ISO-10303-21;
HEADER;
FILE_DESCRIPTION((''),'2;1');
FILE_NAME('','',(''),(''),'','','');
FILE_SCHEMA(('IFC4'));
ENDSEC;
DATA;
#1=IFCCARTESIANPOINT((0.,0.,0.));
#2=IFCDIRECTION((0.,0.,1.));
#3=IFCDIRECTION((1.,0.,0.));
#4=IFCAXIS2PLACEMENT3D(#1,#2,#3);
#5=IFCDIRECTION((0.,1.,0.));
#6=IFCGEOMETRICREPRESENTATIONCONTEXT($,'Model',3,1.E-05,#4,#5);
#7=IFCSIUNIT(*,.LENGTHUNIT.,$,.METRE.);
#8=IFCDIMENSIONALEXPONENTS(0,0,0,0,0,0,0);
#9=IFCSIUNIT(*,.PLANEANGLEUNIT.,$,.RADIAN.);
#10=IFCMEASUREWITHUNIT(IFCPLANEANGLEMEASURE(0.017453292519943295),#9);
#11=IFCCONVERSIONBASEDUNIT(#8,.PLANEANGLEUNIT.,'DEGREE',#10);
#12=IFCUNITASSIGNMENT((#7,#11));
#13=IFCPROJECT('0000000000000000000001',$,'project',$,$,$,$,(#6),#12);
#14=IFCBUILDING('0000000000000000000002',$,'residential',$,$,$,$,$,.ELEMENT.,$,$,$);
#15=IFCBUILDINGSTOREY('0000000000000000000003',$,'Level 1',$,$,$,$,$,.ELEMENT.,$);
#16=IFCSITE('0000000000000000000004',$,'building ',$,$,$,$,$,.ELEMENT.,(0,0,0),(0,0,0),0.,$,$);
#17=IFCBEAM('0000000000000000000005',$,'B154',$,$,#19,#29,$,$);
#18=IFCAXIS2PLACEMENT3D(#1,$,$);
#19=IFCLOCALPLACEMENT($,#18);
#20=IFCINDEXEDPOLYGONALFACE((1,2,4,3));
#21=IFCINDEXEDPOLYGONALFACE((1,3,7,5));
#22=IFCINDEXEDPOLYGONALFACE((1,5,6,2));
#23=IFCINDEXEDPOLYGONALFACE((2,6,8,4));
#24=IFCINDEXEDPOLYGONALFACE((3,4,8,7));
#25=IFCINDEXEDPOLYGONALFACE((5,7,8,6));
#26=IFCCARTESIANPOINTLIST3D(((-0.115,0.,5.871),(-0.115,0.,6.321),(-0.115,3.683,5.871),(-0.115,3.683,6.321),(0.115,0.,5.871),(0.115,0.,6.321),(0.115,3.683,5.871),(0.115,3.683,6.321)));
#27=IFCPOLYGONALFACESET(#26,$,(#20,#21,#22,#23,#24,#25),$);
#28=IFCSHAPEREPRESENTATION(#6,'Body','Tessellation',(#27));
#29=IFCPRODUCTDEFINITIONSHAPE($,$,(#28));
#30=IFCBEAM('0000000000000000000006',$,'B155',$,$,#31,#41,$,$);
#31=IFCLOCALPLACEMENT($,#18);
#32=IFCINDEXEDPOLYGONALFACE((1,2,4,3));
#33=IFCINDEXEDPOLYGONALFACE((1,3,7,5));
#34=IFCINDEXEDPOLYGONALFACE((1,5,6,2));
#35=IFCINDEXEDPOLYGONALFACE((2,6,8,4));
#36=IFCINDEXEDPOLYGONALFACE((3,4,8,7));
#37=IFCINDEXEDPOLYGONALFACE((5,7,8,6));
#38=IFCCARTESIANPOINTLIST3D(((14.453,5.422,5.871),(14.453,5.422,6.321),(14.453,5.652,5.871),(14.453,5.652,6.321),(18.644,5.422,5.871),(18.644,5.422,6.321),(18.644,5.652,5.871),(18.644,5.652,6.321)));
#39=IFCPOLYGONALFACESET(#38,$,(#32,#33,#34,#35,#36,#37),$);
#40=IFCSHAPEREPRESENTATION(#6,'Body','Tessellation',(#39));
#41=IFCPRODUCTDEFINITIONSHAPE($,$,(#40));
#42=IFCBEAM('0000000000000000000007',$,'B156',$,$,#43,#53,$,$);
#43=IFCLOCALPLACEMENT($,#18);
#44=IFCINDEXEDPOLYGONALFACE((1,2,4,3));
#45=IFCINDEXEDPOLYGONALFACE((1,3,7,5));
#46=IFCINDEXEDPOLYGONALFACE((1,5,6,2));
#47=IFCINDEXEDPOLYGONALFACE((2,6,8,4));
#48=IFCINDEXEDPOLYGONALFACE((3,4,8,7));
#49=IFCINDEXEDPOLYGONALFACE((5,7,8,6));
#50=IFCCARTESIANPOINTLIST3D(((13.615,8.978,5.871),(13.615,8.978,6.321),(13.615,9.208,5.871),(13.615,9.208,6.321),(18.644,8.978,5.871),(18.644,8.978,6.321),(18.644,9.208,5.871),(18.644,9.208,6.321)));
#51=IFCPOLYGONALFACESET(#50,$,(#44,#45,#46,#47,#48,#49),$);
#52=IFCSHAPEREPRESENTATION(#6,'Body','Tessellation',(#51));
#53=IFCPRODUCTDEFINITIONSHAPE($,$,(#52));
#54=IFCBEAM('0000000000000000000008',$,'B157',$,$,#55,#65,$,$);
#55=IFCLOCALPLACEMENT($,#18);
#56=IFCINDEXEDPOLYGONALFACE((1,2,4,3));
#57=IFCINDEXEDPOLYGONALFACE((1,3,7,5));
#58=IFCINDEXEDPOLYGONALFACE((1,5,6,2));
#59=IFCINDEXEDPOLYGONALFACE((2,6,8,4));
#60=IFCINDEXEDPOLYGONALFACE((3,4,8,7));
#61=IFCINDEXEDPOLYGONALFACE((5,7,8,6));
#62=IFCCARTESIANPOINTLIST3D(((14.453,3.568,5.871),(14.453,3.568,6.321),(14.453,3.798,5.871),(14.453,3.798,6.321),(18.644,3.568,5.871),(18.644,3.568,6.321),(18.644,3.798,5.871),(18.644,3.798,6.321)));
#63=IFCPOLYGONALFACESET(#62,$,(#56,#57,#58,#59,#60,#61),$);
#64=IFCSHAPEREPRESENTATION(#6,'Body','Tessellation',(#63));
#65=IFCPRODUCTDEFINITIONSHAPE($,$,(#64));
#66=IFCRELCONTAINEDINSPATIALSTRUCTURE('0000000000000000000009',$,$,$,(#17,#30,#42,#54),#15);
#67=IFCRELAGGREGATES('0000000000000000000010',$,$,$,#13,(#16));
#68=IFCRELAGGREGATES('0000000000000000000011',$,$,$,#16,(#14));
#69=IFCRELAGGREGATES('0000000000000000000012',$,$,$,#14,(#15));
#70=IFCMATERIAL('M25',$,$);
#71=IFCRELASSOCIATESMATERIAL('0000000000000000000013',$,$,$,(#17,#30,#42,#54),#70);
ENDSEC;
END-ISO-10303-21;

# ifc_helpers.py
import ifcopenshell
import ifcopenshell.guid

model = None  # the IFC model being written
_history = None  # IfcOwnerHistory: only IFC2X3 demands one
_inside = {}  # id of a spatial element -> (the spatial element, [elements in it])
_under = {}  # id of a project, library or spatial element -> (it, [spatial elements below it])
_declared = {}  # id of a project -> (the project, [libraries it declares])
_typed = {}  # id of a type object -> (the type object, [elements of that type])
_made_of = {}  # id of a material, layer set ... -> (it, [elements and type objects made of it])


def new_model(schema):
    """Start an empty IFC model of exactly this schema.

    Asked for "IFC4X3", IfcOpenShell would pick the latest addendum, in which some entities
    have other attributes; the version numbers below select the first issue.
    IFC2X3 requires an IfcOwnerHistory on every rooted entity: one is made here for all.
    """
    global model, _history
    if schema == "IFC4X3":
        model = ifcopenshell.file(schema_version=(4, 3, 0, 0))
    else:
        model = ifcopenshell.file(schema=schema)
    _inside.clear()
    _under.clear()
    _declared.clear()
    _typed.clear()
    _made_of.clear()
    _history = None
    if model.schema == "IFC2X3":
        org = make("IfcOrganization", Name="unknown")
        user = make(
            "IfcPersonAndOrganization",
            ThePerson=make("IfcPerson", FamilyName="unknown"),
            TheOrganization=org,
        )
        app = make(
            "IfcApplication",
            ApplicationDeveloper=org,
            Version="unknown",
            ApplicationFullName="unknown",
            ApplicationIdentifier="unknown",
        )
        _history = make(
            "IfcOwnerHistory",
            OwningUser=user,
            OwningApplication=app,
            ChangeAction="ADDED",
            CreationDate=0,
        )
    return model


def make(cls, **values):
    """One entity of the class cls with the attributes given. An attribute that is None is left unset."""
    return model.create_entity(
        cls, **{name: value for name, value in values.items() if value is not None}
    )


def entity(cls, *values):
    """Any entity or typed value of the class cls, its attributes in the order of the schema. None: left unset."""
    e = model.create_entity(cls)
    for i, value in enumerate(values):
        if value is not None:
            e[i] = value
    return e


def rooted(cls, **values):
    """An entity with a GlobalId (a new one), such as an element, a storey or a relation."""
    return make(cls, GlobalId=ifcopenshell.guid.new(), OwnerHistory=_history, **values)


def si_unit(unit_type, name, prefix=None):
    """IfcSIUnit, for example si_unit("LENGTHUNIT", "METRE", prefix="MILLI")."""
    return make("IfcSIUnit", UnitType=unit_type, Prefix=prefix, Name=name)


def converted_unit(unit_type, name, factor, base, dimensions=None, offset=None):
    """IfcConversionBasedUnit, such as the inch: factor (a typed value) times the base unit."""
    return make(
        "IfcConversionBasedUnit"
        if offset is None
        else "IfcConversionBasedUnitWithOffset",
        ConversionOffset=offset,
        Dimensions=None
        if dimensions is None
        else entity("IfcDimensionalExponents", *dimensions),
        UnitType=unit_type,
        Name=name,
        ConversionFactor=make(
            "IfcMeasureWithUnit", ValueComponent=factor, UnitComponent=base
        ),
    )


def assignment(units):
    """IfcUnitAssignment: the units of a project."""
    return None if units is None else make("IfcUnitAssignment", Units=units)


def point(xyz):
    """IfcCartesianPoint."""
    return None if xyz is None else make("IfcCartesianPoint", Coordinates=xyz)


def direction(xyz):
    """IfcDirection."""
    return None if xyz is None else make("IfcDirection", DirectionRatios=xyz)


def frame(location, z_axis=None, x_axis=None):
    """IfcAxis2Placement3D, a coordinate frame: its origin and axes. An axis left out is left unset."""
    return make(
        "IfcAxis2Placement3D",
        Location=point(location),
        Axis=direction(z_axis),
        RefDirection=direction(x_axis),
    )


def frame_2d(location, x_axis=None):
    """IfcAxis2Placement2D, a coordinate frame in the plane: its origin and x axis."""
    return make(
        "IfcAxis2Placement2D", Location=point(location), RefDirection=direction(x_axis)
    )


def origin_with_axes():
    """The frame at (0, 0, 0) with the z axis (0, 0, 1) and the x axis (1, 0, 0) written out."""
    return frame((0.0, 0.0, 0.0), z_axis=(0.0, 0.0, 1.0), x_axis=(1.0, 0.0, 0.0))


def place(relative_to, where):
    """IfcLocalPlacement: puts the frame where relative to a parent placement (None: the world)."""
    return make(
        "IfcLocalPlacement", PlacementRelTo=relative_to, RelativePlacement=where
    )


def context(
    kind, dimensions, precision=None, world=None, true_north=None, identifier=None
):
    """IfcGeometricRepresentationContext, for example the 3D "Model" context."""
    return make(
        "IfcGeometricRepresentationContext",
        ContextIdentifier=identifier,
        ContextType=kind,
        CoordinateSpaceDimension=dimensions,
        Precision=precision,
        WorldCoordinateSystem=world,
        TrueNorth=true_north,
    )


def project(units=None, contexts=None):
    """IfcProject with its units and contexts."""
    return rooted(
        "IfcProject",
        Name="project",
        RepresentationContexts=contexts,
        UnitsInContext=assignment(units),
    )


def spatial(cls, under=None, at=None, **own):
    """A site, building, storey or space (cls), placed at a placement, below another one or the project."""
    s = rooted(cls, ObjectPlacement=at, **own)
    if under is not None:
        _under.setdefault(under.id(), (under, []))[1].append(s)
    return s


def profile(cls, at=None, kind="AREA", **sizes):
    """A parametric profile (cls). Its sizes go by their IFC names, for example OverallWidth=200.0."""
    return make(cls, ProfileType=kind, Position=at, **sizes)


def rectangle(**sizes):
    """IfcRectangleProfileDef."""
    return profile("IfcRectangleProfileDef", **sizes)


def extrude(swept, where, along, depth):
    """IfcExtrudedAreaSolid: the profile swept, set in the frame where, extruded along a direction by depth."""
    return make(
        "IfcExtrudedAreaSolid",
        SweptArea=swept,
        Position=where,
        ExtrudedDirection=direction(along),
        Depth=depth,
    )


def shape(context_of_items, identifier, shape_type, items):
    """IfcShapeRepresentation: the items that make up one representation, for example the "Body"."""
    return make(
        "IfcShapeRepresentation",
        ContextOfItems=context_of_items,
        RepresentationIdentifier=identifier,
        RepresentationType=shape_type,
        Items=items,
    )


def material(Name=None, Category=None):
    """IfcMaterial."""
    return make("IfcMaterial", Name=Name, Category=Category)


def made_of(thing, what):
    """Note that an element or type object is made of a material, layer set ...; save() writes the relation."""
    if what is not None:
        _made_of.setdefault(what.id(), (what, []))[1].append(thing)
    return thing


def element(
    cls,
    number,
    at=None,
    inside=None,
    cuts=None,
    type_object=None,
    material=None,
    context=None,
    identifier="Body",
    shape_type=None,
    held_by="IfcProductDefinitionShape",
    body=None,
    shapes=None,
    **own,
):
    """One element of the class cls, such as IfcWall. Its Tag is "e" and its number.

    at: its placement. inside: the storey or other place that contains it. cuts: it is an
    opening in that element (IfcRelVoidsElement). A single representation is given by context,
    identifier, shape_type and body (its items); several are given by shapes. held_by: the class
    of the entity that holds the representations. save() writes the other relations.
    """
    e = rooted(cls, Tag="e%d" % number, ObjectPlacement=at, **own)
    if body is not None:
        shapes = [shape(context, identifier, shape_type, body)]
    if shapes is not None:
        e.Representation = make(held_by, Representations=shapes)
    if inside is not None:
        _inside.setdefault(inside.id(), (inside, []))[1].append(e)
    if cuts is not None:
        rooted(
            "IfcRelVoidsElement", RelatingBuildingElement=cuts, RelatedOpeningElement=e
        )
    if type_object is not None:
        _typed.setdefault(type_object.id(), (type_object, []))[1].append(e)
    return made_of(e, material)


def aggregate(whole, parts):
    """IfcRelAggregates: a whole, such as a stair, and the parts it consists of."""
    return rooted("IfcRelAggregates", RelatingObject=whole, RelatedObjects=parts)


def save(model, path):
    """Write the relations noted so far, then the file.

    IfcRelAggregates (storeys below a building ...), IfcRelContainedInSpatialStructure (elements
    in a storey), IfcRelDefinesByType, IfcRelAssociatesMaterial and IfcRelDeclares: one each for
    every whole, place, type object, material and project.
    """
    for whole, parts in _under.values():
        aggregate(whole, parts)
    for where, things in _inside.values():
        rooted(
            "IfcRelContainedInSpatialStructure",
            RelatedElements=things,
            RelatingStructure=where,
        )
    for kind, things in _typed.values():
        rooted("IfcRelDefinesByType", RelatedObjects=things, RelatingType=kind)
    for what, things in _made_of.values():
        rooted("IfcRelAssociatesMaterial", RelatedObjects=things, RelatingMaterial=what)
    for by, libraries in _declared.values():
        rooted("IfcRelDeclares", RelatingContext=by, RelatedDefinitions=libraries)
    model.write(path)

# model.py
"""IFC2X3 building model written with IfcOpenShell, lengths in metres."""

from ifc_helpers import new_model, entity, si_unit, converted_unit, direction, frame, frame_2d, origin_with_axes, place, context, project, spatial, rectangle, extrude, material, element, save


model = new_model("IFC2X3")

# Units and contexts
model_context = context("Model", 3, precision=1e-05, world=origin_with_axes(), true_north=direction((0.0, 1.0, 0.0)))
ifc_project = project(units=[si_unit("LENGTHUNIT", "METRE"), converted_unit("PLANEANGLEUNIT", "DEGREE", entity("IfcPlaneAngleMeasure", 0.017453292519943295), si_unit("PLANEANGLEUNIT", "RADIAN"), dimensions=[0, 0, 0, 0, 0, 0, 0])], contexts=[model_context])

# Site, building, storey
site = spatial("IfcSite", under=ifc_project, Name="building ", CompositionType="ELEMENT", RefLatitude=(0, 0, 0), RefLongitude=(0, 0, 0), RefElevation=0.0)
building = spatial("IfcBuilding", under=site, Name="residential", CompositionType="ELEMENT")
storey = spatial("IfcBuildingStorey", under=building, Name="Level 1", CompositionType="ELEMENT")

# Shared definitions
ifc_material = material(Name="M25")
placement = place(None, origin_with_axes())

# Beams
element("IfcBeam", 1, at=placement, inside=storey, material=ifc_material, Name="B154", context=model_context, shape_type="SweptSolid", body=[
    extrude(rectangle(XDim=0.23, YDim=0.45, at=frame_2d((0.0, 0.0), x_axis=(0.0, 1.0, 0.0))), frame((0.0, 0.0, 6.096), z_axis=(0.0, 1.0, 0.0), x_axis=(0.0, 0.0, -1.0)), (0.0, 0.0, 1.0), 3.683),
])
element("IfcBeam", 2, at=placement, inside=storey, material=ifc_material, Name="B155", context=model_context, shape_type="SweptSolid", body=[
    extrude(rectangle(XDim=0.23, YDim=0.45, at=frame_2d((0.0, 0.0), x_axis=(0.0, 1.0, 0.0))), frame((18.644, 5.537, 6.096), z_axis=(-1.0, 0.0, 0.0), x_axis=(0.0, 0.0, -1.0)), (0.0, 0.0, 1.0), 4.191),
])
element("IfcBeam", 3, at=placement, inside=storey, material=ifc_material, Name="B156", context=model_context, shape_type="SweptSolid", body=[
    extrude(rectangle(XDim=0.23, YDim=0.45, at=frame_2d((0.0, 0.0), x_axis=(0.0, 1.0, 0.0))), frame((18.644, 9.093, 6.096), z_axis=(-1.0, 0.0, 0.0), x_axis=(0.0, 0.0, -1.0)), (0.0, 0.0, 1.0), 5.029),
])
element("IfcBeam", 4, at=placement, inside=storey, material=ifc_material, Name="B157", context=model_context, shape_type="SweptSolid", body=[
    extrude(rectangle(XDim=0.23, YDim=0.45, at=frame_2d((0.0, 0.0), x_axis=(0.0, 1.0, 0.0))), frame((18.644, 3.683, 6.096), z_axis=(-1.0, 0.0, 0.0), x_axis=(0.0, 0.0, -1.0)), (0.0, 0.0, 1.0), 4.191),
])

save(model, "model.ifc")
